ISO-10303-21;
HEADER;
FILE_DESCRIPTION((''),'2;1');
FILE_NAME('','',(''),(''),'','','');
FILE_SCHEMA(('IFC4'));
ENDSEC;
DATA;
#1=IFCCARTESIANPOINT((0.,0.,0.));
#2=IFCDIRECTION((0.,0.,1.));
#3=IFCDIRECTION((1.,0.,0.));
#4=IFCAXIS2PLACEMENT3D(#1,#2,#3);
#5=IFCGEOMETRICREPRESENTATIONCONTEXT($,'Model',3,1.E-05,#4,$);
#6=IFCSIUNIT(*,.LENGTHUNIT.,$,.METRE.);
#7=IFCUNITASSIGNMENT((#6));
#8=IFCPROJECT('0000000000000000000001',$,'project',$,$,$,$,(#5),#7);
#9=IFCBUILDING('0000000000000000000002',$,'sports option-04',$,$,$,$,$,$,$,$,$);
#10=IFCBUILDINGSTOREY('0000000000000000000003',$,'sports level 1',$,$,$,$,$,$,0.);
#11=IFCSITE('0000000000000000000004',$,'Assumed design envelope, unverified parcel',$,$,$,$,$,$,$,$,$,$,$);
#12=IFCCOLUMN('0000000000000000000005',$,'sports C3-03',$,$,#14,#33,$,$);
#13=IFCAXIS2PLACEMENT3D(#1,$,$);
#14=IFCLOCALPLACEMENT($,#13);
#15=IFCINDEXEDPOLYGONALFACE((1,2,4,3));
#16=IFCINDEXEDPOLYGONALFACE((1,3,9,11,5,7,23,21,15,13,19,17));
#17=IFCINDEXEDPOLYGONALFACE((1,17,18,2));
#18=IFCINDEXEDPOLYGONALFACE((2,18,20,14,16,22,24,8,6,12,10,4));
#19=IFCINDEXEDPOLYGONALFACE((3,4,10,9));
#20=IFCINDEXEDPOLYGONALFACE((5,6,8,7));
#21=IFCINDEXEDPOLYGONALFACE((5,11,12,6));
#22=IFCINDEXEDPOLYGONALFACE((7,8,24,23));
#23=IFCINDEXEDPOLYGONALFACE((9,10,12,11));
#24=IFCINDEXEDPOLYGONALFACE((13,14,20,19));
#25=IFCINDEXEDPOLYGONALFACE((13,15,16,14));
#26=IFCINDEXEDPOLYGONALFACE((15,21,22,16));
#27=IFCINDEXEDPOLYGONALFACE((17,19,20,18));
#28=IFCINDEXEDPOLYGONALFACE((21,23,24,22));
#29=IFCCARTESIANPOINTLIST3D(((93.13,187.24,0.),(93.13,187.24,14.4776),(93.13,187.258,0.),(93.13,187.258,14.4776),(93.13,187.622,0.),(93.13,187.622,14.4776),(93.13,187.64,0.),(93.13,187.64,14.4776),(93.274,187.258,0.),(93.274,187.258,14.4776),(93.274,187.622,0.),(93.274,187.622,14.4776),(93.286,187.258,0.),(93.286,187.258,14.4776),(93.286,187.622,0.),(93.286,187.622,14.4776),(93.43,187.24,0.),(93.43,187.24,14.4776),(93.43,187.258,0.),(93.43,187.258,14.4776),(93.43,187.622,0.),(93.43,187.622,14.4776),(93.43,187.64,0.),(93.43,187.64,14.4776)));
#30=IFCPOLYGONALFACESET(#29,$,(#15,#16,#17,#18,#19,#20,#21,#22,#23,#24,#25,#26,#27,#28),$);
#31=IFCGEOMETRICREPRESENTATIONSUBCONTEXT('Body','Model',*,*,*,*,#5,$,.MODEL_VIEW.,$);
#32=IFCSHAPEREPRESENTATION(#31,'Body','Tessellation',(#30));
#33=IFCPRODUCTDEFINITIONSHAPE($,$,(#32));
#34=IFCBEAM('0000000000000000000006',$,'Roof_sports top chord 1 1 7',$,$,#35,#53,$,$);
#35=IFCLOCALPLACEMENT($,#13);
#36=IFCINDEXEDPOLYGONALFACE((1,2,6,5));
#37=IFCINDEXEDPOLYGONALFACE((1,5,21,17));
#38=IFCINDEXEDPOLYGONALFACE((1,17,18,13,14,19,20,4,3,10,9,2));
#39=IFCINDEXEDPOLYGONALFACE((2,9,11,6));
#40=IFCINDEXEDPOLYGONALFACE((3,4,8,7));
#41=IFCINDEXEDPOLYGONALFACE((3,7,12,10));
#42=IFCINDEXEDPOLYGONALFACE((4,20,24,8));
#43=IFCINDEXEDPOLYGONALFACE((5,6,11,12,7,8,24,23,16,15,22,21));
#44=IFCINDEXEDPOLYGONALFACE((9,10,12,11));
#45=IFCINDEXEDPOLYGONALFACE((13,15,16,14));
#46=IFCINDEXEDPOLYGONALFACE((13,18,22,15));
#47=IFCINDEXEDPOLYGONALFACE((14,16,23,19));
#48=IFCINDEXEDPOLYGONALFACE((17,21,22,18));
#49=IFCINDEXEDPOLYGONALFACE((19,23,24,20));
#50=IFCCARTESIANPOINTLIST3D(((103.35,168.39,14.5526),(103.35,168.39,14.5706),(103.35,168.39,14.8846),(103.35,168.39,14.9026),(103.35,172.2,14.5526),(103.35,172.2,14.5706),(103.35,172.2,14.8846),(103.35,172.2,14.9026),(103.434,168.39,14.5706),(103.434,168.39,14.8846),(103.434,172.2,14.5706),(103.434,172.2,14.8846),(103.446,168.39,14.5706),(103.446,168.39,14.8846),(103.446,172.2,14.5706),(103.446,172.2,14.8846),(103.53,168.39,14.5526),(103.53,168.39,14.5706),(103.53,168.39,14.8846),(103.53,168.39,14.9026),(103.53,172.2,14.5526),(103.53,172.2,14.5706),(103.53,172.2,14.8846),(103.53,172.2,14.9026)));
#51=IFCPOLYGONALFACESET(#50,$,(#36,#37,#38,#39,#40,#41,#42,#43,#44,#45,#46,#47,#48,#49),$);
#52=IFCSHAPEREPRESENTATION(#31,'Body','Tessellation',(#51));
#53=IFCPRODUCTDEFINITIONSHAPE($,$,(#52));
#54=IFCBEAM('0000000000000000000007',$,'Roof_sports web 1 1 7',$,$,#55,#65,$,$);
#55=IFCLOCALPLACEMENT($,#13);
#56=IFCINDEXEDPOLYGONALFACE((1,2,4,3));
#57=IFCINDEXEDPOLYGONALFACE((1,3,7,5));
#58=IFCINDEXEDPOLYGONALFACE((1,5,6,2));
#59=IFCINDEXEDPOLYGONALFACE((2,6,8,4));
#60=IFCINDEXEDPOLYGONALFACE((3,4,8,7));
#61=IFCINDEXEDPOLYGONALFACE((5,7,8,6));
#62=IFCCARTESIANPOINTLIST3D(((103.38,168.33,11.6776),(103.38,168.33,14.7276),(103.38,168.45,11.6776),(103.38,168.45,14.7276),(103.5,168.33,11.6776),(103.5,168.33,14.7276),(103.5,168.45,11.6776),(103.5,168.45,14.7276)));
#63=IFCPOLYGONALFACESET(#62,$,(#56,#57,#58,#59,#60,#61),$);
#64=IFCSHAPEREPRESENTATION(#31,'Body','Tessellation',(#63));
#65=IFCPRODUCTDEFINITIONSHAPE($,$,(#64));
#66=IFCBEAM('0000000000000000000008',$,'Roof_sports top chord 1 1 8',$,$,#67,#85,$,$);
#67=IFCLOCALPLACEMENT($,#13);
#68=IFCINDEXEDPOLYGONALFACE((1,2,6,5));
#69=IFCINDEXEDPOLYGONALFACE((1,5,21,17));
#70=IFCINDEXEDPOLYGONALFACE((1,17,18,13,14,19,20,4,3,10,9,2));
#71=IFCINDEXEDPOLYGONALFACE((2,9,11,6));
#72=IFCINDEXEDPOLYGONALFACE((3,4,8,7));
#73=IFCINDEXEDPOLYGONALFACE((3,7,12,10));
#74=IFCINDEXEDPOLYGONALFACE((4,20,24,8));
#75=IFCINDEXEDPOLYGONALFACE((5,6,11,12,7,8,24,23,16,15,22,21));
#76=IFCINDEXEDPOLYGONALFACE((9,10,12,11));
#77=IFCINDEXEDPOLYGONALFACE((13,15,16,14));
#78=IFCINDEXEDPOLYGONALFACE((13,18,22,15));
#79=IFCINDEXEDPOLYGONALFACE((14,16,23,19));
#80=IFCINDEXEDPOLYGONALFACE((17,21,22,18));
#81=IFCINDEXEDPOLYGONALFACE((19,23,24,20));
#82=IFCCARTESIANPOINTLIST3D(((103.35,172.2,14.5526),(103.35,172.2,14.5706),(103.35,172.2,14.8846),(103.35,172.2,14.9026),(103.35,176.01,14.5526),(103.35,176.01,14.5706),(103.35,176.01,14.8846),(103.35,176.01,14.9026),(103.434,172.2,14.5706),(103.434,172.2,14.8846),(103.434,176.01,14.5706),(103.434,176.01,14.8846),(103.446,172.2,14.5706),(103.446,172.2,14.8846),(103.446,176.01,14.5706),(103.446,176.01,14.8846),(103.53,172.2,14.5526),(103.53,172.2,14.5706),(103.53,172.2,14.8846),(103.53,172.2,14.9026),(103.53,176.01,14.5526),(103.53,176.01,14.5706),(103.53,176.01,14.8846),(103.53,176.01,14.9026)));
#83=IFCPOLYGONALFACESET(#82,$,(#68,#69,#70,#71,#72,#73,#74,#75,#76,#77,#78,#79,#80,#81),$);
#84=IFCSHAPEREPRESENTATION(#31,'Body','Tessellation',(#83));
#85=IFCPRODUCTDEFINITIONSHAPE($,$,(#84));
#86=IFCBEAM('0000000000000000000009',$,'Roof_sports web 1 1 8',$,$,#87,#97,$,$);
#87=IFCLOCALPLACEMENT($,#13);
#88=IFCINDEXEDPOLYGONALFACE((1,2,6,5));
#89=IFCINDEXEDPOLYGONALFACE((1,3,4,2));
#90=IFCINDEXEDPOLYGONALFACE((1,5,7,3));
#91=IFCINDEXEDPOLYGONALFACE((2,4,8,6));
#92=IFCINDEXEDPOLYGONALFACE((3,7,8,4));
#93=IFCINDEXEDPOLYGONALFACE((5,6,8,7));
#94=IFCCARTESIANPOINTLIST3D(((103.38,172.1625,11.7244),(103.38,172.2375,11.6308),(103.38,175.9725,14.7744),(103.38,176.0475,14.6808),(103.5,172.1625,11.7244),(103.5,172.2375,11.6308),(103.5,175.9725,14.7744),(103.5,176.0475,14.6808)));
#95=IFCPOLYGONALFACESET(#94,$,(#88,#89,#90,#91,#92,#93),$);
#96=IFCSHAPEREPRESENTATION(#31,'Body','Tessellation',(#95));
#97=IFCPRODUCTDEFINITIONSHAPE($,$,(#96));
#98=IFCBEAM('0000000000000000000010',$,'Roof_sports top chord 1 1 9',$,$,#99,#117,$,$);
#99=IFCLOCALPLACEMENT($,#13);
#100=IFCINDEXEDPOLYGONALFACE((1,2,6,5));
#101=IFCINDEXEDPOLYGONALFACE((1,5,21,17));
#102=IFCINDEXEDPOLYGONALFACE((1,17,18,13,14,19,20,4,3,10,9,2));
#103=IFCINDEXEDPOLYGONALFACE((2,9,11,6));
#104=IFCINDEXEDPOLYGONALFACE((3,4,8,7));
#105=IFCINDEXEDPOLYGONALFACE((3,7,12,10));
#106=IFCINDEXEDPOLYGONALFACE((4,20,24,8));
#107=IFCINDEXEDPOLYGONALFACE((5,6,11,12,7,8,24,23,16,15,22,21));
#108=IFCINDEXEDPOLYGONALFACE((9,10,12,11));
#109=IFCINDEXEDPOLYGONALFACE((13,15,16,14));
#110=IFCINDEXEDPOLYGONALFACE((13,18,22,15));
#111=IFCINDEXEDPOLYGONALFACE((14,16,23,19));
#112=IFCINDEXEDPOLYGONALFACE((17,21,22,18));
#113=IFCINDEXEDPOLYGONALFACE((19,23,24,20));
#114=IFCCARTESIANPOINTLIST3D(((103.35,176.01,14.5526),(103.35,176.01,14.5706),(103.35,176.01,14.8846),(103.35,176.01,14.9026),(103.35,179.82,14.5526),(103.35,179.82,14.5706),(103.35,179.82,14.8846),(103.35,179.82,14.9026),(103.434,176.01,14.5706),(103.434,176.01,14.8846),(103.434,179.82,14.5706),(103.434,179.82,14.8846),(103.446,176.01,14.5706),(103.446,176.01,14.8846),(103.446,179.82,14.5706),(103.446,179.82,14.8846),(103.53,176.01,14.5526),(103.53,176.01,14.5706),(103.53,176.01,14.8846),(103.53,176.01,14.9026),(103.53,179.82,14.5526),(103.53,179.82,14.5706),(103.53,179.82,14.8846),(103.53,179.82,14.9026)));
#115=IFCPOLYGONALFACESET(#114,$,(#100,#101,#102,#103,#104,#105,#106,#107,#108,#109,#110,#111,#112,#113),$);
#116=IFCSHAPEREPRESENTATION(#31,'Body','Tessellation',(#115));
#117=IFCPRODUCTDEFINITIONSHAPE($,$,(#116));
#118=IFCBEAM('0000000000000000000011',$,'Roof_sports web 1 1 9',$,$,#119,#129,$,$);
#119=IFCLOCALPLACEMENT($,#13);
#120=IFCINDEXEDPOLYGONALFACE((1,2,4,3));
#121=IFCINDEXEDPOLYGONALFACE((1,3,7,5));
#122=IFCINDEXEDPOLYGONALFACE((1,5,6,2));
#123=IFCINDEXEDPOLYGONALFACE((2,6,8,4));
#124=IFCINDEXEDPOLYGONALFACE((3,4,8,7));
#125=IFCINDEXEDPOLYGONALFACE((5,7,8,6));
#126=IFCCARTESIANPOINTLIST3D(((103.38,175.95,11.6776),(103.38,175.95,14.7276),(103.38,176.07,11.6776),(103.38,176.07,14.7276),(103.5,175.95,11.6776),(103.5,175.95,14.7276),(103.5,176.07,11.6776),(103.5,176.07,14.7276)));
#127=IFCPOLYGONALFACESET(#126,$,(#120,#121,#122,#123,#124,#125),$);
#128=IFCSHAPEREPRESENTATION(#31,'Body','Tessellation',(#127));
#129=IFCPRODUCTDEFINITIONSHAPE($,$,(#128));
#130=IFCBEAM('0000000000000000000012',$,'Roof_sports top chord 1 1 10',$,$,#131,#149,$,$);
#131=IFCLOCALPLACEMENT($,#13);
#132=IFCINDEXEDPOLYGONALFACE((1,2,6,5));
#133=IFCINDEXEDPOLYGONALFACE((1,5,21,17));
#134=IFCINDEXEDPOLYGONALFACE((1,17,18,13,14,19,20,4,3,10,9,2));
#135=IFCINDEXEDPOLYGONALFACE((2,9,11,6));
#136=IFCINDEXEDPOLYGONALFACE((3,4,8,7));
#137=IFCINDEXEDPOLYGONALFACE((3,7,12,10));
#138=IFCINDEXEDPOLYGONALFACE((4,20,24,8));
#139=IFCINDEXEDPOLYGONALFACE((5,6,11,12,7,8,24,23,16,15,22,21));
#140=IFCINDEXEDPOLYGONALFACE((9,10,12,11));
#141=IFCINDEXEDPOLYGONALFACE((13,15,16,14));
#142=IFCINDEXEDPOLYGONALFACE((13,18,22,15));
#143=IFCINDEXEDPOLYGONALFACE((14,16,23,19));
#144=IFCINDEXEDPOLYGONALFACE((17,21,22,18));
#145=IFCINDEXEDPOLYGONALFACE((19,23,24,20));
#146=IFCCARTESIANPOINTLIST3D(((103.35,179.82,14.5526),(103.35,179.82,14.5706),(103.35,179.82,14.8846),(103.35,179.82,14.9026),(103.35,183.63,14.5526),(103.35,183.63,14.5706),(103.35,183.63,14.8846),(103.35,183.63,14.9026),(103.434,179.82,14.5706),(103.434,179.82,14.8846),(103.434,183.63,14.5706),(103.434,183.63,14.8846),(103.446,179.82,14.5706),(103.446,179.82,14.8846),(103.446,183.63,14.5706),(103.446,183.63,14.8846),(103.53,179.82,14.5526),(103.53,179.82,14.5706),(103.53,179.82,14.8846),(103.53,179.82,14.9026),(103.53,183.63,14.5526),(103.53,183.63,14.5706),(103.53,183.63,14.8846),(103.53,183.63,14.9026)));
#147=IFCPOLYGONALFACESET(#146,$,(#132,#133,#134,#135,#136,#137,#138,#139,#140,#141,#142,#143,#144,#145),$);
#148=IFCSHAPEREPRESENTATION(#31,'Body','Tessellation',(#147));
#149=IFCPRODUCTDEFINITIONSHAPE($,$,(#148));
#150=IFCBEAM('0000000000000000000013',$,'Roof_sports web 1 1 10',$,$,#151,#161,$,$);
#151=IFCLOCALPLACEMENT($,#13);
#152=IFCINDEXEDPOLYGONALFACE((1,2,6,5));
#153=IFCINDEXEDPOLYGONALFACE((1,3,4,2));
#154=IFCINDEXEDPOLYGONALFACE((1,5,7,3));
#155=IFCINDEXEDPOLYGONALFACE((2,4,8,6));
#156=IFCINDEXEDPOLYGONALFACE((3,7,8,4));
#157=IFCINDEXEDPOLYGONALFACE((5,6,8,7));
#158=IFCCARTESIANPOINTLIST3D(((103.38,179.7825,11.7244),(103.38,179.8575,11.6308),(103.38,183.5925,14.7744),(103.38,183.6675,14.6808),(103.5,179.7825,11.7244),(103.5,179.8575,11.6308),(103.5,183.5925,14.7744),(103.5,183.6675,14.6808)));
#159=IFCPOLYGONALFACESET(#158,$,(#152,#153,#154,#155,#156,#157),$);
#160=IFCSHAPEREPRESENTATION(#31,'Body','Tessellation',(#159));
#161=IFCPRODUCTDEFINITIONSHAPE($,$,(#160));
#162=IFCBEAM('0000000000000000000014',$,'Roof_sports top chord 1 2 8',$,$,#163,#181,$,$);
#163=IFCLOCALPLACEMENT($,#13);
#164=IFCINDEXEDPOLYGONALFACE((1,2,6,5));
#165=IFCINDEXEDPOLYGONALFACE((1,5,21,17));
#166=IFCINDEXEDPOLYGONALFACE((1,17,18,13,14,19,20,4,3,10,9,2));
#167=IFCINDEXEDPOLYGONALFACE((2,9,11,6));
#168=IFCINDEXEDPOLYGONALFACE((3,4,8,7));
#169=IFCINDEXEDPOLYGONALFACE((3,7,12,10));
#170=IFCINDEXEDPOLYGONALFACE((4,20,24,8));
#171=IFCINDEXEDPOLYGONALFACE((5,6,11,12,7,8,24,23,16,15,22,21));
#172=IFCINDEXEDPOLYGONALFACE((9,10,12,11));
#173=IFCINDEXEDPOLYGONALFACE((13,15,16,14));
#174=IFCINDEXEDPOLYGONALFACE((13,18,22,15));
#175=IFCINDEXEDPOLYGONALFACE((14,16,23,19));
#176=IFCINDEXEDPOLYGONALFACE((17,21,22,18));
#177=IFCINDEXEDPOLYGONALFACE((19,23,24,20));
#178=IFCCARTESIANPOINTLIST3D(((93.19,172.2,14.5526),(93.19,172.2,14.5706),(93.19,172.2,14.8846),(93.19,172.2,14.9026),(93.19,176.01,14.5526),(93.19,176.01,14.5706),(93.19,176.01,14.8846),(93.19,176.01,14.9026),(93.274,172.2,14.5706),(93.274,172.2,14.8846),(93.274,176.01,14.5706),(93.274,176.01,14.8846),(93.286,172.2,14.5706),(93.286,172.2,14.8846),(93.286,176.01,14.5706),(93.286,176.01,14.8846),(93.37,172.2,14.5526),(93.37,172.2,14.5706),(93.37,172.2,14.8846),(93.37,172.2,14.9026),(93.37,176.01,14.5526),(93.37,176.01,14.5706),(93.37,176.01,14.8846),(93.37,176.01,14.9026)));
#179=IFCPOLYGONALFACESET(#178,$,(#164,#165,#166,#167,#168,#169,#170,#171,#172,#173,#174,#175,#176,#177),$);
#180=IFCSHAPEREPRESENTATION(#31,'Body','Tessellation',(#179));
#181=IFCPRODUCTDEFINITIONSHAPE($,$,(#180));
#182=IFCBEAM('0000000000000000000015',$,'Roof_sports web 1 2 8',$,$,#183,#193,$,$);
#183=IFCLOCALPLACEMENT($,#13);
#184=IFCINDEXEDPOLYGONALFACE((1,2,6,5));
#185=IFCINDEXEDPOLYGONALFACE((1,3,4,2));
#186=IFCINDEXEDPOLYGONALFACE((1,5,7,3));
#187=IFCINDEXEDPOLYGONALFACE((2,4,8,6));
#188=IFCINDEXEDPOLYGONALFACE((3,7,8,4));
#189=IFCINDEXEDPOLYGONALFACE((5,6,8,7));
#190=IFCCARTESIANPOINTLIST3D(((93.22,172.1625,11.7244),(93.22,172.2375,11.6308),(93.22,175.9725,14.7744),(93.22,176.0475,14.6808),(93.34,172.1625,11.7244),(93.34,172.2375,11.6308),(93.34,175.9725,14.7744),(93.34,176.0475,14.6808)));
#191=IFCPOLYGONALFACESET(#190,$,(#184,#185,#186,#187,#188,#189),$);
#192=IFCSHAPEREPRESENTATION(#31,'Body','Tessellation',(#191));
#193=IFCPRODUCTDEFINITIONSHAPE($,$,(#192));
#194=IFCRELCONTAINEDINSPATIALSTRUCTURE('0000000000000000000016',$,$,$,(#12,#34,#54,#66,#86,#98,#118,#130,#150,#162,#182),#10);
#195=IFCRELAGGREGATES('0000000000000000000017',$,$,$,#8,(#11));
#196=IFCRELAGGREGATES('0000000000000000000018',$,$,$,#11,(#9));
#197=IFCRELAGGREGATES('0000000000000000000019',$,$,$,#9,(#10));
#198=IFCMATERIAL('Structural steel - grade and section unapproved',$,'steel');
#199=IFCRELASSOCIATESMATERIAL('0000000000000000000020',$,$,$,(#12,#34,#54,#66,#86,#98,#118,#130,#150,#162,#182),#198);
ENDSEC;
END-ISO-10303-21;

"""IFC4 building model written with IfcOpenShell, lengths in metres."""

from ifc_helpers import new_model, si_unit, frame, origin_with_axes, place, context, subcontext, project, spatial, rectangle, i_section, extrude, material, element, save


model = new_model("IFC4")

# Units and contexts
model_context = context("Model", 3, precision=1e-05, world=origin_with_axes())
body_context = subcontext(model_context, "Body", "Model", "MODEL_VIEW")
ifc_project = project(units=[si_unit("LENGTHUNIT", "METRE")], contexts=[model_context])

# Site, building, storey
site = spatial("IfcSite", under=ifc_project, Name="Assumed design envelope, unverified parcel")
building = spatial("IfcBuilding", under=site, Name="sports option-04")
storey = spatial("IfcBuildingStorey", under=building, Name="sports level 1", Elevation=0.0)

# Column
ifc_material_1 = material(Name="Structural steel - grade and section unapproved", Category="steel")
column_placement = place(None, frame((93.28, 187.44, 0.0), z_axis=(0.0, 0.0, 1.0), x_axis=(-1.0, 0.0, 0.0)))
element("IfcColumn", 1, at=column_placement, inside=storey, material=ifc_material_1, Name="sports C3-03", context=body_context, shape_type="SweptSolid", body=[
    extrude(i_section(OverallWidth=0.3, OverallDepth=0.4, WebThickness=0.012, FlangeThickness=0.018, FilletRadius=0.0), origin_with_axes(), (0.0, 0.0, 1.0), 14.4776),
])

# Beams
beam_1_placement = place(None, frame((103.44, 168.39, 14.7276), z_axis=(0.0, 1.0, 0.0), x_axis=(-1.0, 0.0, 0.0)))
element("IfcBeam", 2, at=beam_1_placement, inside=storey, material=ifc_material_1, Name="Roof_sports top chord 1 1 7", context=body_context, shape_type="SweptSolid", body=[
    extrude(i_section(OverallWidth=0.18, OverallDepth=0.35, WebThickness=0.012, FlangeThickness=0.018, FilletRadius=0.0), origin_with_axes(), (0.0, 0.0, 1.0), 3.81),
])
beam_2_placement = place(None, frame((103.44, 168.39, 11.6776), z_axis=(0.0, 0.0, 1.0), x_axis=(-1.0, 0.0, 0.0)))
element("IfcBeam", 3, at=beam_2_placement, inside=storey, material=ifc_material_1, Name="Roof_sports web 1 1 7", context=body_context, shape_type="SweptSolid", body=[
    extrude(rectangle(XDim=0.12, YDim=0.12), origin_with_axes(), (0.0, 0.0, 1.0), 3.05),
])
beam_3_placement = place(None, frame((103.44, 172.2, 14.7276), z_axis=(0.0, 1.0, 0.0), x_axis=(-1.0, 0.0, 0.0)))
element("IfcBeam", 4, at=beam_3_placement, inside=storey, material=ifc_material_1, Name="Roof_sports top chord 1 1 8", context=body_context, shape_type="SweptSolid", body=[
    extrude(i_section(OverallWidth=0.18, OverallDepth=0.35, WebThickness=0.012, FlangeThickness=0.018, FilletRadius=0.0), origin_with_axes(), (0.0, 0.0, 1.0), 3.81),
])
beam_4_placement = place(None, frame((103.44, 172.2, 11.6776), z_axis=(0.0, 0.780669, 0.624945), x_axis=(-1.0, 0.0, 0.0)))
element("IfcBeam", 5, at=beam_4_placement, inside=storey, material=ifc_material_1, Name="Roof_sports web 1 1 8", context=body_context, shape_type="SweptSolid", body=[
    extrude(rectangle(XDim=0.12, YDim=0.12), origin_with_axes(), (0.0, 0.0, 1.0), 4.8804),
])
beam_5_placement = place(None, frame((103.44, 176.01, 14.7276), z_axis=(0.0, 1.0, 0.0), x_axis=(-1.0, 0.0, 0.0)))
element("IfcBeam", 6, at=beam_5_placement, inside=storey, material=ifc_material_1, Name="Roof_sports top chord 1 1 9", context=body_context, shape_type="SweptSolid", body=[
    extrude(i_section(OverallWidth=0.18, OverallDepth=0.35, WebThickness=0.012, FlangeThickness=0.018, FilletRadius=0.0), origin_with_axes(), (0.0, 0.0, 1.0), 3.81),
])
beam_6_placement = place(None, frame((103.44, 176.01, 11.6776), z_axis=(0.0, 0.0, 1.0), x_axis=(-1.0, 0.0, 0.0)))
element("IfcBeam", 7, at=beam_6_placement, inside=storey, material=ifc_material_1, Name="Roof_sports web 1 1 9", context=body_context, shape_type="SweptSolid", body=[
    extrude(rectangle(XDim=0.12, YDim=0.12), origin_with_axes(), (0.0, 0.0, 1.0), 3.05),
])
beam_7_placement = place(None, frame((103.44, 179.82, 14.7276), z_axis=(0.0, 1.0, 0.0), x_axis=(-1.0, 0.0, 0.0)))
element("IfcBeam", 8, at=beam_7_placement, inside=storey, material=ifc_material_1, Name="Roof_sports top chord 1 1 10", context=body_context, shape_type="SweptSolid", body=[
    extrude(i_section(OverallWidth=0.18, OverallDepth=0.35, WebThickness=0.012, FlangeThickness=0.018, FilletRadius=0.0), origin_with_axes(), (0.0, 0.0, 1.0), 3.81),
])
beam_8_placement = place(None, frame((103.44, 179.82, 11.6776), z_axis=(0.0, 0.780669, 0.624945), x_axis=(-1.0, 0.0, 0.0)))
element("IfcBeam", 9, at=beam_8_placement, inside=storey, material=ifc_material_1, Name="Roof_sports web 1 1 10", context=body_context, shape_type="SweptSolid", body=[
    extrude(rectangle(XDim=0.12, YDim=0.12), origin_with_axes(), (0.0, 0.0, 1.0), 4.8804),
])
beam_9_placement = place(None, frame((93.28, 172.2, 14.7276), z_axis=(0.0, 1.0, 0.0), x_axis=(-1.0, 0.0, 0.0)))
element("IfcBeam", 10, at=beam_9_placement, inside=storey, material=ifc_material_1, Name="Roof_sports top chord 1 2 8", context=body_context, shape_type="SweptSolid", body=[
    extrude(i_section(OverallWidth=0.18, OverallDepth=0.35, WebThickness=0.012, FlangeThickness=0.018, FilletRadius=0.0), origin_with_axes(), (0.0, 0.0, 1.0), 3.81),
])
beam_10_placement = place(None, frame((93.28, 172.2, 11.6776), z_axis=(0.0, 0.780669, 0.624945), x_axis=(-1.0, 0.0, 0.0)))
element("IfcBeam", 11, at=beam_10_placement, inside=storey, material=ifc_material_1, Name="Roof_sports web 1 2 8", context=body_context, shape_type="SweptSolid", body=[
    extrude(rectangle(XDim=0.12, YDim=0.12), origin_with_axes(), (0.0, 0.0, 1.0), 4.8804),
])

save(model, "model.ifc")
